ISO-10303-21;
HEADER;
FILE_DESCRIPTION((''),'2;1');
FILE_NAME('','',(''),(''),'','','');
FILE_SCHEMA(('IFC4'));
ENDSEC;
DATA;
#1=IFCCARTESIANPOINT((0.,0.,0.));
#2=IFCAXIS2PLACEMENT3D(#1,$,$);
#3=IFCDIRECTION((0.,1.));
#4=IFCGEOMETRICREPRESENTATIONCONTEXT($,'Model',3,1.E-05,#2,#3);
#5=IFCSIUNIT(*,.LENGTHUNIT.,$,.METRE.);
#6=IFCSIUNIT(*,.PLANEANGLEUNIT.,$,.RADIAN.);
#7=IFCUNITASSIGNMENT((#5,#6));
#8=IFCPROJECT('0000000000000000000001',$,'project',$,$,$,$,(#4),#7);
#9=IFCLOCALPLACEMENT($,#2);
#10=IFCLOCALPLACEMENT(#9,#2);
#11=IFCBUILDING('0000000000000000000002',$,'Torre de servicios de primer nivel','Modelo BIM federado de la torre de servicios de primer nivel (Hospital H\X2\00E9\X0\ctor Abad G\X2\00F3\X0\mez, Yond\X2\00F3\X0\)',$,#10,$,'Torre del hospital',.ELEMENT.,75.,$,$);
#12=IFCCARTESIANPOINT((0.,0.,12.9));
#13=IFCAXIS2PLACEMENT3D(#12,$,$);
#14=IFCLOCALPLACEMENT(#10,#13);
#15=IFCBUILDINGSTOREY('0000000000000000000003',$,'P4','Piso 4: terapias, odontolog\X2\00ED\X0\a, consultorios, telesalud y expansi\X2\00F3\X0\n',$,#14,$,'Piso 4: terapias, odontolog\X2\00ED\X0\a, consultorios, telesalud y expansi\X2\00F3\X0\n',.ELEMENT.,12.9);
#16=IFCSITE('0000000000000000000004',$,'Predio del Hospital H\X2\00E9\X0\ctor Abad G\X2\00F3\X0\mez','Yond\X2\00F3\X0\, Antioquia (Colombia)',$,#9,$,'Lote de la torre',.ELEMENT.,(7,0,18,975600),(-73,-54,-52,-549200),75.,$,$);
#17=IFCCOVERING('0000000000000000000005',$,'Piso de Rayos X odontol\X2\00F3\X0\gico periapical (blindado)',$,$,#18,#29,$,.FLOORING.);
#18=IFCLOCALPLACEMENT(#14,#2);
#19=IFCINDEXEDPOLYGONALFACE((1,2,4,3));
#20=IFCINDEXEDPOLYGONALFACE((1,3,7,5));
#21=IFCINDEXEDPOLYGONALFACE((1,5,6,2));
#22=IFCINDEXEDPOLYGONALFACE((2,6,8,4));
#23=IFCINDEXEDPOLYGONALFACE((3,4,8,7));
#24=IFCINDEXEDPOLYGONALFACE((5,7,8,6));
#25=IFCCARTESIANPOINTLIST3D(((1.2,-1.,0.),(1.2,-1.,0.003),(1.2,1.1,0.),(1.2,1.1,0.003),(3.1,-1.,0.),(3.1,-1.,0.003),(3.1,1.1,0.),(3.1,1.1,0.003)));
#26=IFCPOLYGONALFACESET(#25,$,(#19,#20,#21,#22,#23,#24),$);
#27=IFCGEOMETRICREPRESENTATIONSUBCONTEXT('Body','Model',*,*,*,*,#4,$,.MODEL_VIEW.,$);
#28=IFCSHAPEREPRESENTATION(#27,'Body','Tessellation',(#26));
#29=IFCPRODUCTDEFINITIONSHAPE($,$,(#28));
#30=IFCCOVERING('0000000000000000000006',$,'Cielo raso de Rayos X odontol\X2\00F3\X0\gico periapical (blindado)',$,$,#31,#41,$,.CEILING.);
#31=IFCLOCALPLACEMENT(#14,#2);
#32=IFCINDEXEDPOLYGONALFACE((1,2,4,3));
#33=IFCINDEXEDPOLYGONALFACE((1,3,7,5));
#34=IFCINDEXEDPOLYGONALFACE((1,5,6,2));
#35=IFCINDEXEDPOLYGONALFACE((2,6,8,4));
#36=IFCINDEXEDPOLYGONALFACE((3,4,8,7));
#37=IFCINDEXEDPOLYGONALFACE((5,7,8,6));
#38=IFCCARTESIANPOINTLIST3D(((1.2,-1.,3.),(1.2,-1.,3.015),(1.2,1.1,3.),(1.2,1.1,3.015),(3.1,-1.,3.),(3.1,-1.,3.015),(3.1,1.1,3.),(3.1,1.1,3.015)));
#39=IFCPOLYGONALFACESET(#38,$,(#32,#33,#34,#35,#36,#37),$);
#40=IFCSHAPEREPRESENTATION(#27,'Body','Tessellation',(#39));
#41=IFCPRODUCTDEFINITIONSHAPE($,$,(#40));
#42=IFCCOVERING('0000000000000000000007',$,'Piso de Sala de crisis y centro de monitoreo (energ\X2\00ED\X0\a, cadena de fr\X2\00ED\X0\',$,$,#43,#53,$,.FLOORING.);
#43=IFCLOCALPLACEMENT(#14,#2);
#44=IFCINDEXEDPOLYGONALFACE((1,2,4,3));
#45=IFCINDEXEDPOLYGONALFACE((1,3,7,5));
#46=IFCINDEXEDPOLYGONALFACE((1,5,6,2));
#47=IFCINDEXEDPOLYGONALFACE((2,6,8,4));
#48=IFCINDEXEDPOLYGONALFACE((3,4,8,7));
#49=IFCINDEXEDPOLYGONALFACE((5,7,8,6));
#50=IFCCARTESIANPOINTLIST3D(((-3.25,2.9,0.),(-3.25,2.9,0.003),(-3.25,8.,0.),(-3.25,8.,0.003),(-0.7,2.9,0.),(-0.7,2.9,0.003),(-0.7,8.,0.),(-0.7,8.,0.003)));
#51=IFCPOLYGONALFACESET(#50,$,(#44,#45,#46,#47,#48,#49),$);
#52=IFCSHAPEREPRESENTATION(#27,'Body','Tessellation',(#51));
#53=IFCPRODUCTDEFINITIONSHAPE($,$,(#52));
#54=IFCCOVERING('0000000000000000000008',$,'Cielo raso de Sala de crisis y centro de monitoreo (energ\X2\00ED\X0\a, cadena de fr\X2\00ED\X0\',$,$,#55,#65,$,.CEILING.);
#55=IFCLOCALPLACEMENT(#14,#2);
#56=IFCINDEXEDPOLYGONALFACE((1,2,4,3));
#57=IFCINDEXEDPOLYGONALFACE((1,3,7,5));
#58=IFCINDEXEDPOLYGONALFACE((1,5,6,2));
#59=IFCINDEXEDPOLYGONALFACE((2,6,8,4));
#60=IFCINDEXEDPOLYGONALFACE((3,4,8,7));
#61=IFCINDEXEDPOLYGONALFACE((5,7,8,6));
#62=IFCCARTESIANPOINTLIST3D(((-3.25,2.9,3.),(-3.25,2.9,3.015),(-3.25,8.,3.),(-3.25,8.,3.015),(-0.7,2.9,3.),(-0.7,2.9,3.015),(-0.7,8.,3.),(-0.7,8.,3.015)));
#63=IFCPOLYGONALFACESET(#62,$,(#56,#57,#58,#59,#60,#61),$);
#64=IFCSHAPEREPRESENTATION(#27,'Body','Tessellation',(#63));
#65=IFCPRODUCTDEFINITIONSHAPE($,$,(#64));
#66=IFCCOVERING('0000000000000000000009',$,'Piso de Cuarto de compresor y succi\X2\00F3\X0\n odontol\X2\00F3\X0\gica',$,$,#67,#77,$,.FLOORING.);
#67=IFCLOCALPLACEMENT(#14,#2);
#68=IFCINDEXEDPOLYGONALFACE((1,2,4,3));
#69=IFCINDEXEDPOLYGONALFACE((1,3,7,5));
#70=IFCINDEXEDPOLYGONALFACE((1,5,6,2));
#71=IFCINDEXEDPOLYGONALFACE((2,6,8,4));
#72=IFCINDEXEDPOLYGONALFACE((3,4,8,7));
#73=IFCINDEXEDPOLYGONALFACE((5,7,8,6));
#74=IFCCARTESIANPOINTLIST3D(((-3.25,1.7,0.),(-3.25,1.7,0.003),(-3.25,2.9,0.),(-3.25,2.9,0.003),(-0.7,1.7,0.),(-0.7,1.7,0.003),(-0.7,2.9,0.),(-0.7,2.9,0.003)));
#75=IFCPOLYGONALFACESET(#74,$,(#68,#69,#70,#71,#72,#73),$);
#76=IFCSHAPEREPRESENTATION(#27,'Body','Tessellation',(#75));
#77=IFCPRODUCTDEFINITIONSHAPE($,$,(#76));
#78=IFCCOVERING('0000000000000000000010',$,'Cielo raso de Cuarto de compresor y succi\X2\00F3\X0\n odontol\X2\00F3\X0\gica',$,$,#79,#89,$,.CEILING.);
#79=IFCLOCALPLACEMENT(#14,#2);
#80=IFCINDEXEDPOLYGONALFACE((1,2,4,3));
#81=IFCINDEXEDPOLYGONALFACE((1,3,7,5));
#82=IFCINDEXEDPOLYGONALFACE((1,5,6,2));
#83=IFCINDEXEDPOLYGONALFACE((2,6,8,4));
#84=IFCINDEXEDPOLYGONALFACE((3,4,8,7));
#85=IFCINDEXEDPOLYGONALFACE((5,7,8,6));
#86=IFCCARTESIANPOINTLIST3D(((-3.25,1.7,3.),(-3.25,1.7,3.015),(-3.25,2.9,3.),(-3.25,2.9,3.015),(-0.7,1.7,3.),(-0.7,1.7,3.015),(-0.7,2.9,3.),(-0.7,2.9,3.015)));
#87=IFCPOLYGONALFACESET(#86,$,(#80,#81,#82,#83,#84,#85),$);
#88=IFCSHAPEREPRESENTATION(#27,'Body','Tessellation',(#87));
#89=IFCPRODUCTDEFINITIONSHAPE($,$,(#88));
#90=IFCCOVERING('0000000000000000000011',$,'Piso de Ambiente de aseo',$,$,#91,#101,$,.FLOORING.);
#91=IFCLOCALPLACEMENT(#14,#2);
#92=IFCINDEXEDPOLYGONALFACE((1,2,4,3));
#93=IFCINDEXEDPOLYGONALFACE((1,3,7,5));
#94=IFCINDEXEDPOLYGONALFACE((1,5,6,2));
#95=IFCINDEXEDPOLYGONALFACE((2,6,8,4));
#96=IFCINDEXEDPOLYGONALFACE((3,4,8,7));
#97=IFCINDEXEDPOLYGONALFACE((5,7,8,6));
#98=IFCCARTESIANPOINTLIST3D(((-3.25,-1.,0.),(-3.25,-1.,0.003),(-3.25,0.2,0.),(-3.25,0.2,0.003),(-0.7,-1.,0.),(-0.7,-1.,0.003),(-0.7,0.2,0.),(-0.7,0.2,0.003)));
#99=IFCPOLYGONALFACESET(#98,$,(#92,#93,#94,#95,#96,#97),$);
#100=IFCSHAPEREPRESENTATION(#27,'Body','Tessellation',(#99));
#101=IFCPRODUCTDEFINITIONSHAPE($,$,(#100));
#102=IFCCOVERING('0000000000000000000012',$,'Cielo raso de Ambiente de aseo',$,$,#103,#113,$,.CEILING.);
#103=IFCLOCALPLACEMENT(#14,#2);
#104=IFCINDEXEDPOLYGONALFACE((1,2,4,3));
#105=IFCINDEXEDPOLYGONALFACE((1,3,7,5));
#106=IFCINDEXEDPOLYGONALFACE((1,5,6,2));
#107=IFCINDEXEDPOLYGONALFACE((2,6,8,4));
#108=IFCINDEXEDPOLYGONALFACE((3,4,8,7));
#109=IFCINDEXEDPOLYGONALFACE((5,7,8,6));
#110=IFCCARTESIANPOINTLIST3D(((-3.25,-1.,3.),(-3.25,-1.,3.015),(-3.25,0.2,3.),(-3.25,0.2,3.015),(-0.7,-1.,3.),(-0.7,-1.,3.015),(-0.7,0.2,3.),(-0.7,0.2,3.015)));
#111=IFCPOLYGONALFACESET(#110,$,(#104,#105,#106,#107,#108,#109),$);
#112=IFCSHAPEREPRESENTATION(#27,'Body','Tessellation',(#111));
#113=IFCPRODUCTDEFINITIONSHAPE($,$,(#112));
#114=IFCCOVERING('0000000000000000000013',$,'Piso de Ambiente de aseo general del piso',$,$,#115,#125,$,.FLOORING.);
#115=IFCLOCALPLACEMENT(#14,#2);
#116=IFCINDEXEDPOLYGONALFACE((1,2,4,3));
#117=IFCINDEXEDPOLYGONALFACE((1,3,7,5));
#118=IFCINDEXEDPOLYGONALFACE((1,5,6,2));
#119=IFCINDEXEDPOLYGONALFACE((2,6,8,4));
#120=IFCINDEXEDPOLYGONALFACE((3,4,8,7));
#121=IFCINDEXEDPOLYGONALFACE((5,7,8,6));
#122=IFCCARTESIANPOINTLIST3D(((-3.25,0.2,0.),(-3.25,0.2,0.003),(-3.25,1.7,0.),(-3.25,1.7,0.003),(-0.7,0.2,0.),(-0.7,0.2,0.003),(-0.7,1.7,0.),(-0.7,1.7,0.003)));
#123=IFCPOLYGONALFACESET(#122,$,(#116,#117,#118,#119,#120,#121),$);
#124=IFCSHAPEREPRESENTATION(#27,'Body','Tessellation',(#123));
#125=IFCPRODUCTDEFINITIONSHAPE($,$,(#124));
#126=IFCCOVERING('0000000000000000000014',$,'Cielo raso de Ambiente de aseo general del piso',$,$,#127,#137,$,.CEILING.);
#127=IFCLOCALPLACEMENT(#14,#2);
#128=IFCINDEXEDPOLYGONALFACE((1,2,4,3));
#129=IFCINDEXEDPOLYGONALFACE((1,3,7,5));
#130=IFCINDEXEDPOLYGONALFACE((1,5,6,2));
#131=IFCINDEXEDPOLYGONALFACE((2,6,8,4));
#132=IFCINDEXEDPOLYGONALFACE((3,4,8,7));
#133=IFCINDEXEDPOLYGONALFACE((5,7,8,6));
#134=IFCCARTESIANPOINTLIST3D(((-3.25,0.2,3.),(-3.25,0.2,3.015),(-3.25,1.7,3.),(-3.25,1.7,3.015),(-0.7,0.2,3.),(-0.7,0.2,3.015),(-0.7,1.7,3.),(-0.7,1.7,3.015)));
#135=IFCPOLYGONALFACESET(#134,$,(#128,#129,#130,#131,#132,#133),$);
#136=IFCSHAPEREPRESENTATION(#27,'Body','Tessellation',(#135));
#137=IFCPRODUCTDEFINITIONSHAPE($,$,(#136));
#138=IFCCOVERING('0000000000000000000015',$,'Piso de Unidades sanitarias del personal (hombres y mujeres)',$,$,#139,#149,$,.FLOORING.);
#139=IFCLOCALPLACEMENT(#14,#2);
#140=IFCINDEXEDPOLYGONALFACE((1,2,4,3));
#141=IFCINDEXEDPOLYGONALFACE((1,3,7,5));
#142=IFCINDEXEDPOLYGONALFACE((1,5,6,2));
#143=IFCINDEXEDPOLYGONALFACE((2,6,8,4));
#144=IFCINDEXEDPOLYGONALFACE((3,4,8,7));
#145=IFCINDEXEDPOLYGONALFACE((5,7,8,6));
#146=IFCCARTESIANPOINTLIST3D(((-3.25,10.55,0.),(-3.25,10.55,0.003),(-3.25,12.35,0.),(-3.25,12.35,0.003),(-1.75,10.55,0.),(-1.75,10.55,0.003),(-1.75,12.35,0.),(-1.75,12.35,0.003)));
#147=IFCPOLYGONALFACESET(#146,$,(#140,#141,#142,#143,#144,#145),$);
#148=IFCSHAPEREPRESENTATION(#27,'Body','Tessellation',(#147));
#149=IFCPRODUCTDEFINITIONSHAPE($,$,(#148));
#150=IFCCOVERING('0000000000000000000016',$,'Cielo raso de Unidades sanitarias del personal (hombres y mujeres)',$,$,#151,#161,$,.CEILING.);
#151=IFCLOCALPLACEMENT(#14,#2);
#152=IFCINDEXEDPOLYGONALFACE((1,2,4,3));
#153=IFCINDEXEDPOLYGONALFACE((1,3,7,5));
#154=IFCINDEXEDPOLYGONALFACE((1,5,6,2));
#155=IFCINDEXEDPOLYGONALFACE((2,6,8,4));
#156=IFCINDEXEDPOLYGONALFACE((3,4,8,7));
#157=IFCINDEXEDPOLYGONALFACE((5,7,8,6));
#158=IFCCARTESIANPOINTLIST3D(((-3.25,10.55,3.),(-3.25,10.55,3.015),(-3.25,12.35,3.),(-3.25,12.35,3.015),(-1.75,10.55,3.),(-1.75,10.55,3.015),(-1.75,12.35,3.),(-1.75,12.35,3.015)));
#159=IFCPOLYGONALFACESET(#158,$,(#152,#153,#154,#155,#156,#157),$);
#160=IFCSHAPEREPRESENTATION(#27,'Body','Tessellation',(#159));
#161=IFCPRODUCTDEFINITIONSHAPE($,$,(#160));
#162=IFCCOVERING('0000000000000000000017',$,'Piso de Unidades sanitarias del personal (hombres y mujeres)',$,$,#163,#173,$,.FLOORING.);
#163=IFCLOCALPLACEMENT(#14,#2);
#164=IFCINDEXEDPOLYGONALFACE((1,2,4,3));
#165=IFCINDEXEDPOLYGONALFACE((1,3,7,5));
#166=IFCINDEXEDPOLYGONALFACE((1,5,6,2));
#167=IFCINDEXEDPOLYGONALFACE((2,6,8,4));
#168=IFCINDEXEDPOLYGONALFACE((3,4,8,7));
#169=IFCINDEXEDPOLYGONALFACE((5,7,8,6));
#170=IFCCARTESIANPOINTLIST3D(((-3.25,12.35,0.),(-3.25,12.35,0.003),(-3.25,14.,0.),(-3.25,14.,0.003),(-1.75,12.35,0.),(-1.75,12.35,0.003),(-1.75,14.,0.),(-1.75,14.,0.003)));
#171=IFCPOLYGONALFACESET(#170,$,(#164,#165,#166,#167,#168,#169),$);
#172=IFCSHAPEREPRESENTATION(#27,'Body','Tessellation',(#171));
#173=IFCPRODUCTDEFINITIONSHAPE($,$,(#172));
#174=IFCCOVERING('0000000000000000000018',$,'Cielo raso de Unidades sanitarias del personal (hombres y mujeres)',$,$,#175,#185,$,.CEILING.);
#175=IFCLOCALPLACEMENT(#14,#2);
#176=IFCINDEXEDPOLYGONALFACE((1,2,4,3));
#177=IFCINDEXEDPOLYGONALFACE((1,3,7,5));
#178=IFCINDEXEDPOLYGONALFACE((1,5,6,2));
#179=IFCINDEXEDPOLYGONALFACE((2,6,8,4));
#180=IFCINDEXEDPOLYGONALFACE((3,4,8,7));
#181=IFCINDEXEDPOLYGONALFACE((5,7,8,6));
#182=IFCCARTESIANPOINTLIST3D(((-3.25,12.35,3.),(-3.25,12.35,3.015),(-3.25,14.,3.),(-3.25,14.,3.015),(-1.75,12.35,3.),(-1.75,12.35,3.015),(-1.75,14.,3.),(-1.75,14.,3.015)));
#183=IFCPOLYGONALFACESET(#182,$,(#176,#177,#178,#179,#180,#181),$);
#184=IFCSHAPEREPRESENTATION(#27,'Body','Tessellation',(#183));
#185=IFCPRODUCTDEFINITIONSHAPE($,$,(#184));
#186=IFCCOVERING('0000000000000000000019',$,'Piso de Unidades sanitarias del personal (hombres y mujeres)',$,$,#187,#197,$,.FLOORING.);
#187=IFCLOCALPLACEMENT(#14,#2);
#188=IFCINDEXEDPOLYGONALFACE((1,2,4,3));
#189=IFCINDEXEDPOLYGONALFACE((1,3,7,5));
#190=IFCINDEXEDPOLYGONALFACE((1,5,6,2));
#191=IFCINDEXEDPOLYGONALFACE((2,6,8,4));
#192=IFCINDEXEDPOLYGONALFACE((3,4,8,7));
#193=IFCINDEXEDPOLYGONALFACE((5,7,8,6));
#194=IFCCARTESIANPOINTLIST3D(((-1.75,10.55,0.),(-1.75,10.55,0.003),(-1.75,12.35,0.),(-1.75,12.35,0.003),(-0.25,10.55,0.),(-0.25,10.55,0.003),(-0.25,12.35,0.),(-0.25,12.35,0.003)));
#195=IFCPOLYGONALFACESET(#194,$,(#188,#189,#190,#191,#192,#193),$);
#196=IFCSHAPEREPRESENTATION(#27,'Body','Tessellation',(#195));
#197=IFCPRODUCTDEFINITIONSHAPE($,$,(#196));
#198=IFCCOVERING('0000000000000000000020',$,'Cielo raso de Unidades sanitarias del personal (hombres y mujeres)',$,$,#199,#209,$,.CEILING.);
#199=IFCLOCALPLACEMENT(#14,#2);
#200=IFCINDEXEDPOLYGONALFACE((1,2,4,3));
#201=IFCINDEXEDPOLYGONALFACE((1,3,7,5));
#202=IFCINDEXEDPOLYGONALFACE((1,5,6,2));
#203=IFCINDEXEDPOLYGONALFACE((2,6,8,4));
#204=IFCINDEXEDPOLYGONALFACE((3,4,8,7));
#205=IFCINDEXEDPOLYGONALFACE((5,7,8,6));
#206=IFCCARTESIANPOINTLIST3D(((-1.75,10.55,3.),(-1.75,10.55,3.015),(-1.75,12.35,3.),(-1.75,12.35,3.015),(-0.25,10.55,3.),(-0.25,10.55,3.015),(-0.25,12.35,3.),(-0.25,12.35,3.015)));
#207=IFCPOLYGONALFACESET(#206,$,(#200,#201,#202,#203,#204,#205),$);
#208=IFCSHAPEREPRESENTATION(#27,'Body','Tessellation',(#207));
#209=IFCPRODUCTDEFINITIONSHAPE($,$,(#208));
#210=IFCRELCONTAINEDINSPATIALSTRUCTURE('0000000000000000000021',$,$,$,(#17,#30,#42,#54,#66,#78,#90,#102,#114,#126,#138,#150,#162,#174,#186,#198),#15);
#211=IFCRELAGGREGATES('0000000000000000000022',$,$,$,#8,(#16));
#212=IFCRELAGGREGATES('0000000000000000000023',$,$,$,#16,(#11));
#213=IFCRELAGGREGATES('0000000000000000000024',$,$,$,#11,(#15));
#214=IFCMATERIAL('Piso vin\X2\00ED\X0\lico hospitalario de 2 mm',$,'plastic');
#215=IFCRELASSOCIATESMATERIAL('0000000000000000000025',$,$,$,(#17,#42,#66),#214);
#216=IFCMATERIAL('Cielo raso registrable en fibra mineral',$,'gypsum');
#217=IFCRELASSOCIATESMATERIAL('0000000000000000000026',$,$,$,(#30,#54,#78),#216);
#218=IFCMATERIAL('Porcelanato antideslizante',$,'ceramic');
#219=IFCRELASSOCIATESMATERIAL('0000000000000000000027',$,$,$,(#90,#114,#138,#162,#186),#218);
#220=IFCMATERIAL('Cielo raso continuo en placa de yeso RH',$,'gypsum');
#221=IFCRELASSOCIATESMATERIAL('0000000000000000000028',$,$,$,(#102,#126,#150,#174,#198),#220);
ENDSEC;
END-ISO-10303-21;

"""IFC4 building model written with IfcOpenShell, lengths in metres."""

from ifc_helpers import new_model, si_unit, direction, frame, origin, place, context, subcontext, project, spatial, indexed_curve, outline, extrude, material, element, save


model = new_model("IFC4")

# Units and contexts
model_context = context("Model", 3, precision=1e-05, world=origin(), true_north=direction((0.0, 1.0)))
body_context = subcontext(model_context, "Body", "Model", "MODEL_VIEW")
ifc_project = project(units=[si_unit("LENGTHUNIT", "METRE"), si_unit("PLANEANGLEUNIT", "RADIAN")], contexts=[model_context])

# Site, building, storey
site_placement = place(None, origin())
site = spatial("IfcSite", under=ifc_project, at=site_placement, Name="Predio del Hospital Héctor Abad Gómez", Description="Yondó, Antioquia (Colombia)", LongName="Lote de la torre", CompositionType="ELEMENT", RefLatitude=(7, 0, 18, 975600), RefLongitude=(-73, -54, -52, -549200), RefElevation=75.0)
building_placement = place(site_placement, origin())
building = spatial("IfcBuilding", under=site, at=building_placement, Name="Torre de servicios de primer nivel", Description="Modelo BIM federado de la torre de servicios de primer nivel (Hospital Héctor Abad Gómez, Yondó)", LongName="Torre del hospital", CompositionType="ELEMENT", ElevationOfRefHeight=75.0)
placement = place(building_placement, frame((0.0, 0.0, 12.9)))
storey = spatial("IfcBuildingStorey", under=building, at=placement, Name="P4", Description="Piso 4: terapias, odontología, consultorios, telesalud y expansión", LongName="Piso 4: terapias, odontología, consultorios, telesalud y expansión", CompositionType="ELEMENT", Elevation=12.9)

# Coverings
ifc_material_1 = material(Name="Porcelanato antideslizante", Category="ceramic")
ifc_material_2 = material(Name="Cielo raso continuo en placa de yeso RH", Category="gypsum")
ifc_material_3 = material(Name="Piso vinílico hospitalario de 2 mm", Category="plastic")
ifc_material_4 = material(Name="Cielo raso registrable en fibra mineral", Category="gypsum")
element("IfcCovering", 1, at=placement, inside=storey, material=ifc_material_3, Name="Piso de Rayos X odontológico periapical (blindado)", PredefinedType="FLOORING", context=body_context, shape_type="SweptSolid", body=[
    extrude(outline(indexed_curve([(1.2, -1.0), (3.1, -1.0), (3.1, 1.1), (1.2, 1.1), (1.2, -1.0)], self_intersect=False)), origin(), (0.0, 0.0, 1.0), 0.003),
])
element("IfcCovering", 2, at=placement, inside=storey, material=ifc_material_4, Name="Cielo raso de Rayos X odontológico periapical (blindado)", PredefinedType="CEILING", context=body_context, shape_type="SweptSolid", body=[
    extrude(outline(indexed_curve([(1.2, -1.0), (3.1, -1.0), (3.1, 1.1), (1.2, 1.1), (1.2, -1.0)], self_intersect=False)), frame((0.0, 0.0, 3.0)), (0.0, 0.0, 1.0), 0.015),
])
element("IfcCovering", 3, at=placement, inside=storey, material=ifc_material_3, Name="Piso de Sala de crisis y centro de monitoreo (energía, cadena de frí", PredefinedType="FLOORING", context=body_context, shape_type="SweptSolid", body=[
    extrude(outline(indexed_curve([(-3.25, 2.9), (-0.7, 2.9), (-0.7, 8.0), (-3.25, 8.0), (-3.25, 2.9)], self_intersect=False)), origin(), (0.0, 0.0, 1.0), 0.003),
])
element("IfcCovering", 4, at=placement, inside=storey, material=ifc_material_4, Name="Cielo raso de Sala de crisis y centro de monitoreo (energía, cadena de frí", PredefinedType="CEILING", context=body_context, shape_type="SweptSolid", body=[
    extrude(outline(indexed_curve([(-3.25, 2.9), (-0.7, 2.9), (-0.7, 8.0), (-3.25, 8.0), (-3.25, 2.9)], self_intersect=False)), frame((0.0, 0.0, 3.0)), (0.0, 0.0, 1.0), 0.015),
])
element("IfcCovering", 5, at=placement, inside=storey, material=ifc_material_3, Name="Piso de Cuarto de compresor y succión odontológica", PredefinedType="FLOORING", context=body_context, shape_type="SweptSolid", body=[
    extrude(outline(indexed_curve([(-3.25, 1.7), (-0.7, 1.7), (-0.7, 2.9), (-3.25, 2.9), (-3.25, 1.7)], self_intersect=False)), origin(), (0.0, 0.0, 1.0), 0.003),
])
element("IfcCovering", 6, at=placement, inside=storey, material=ifc_material_4, Name="Cielo raso de Cuarto de compresor y succión odontológica", PredefinedType="CEILING", context=body_context, shape_type="SweptSolid", body=[
    extrude(outline(indexed_curve([(-3.25, 1.7), (-0.7, 1.7), (-0.7, 2.9), (-3.25, 2.9), (-3.25, 1.7)], self_intersect=False)), frame((0.0, 0.0, 3.0)), (0.0, 0.0, 1.0), 0.015),
])
element("IfcCovering", 7, at=placement, inside=storey, material=ifc_material_1, Name="Piso de Ambiente de aseo", PredefinedType="FLOORING", context=body_context, shape_type="SweptSolid", body=[
    extrude(outline(indexed_curve([(-3.25, -1.0), (-0.7, -1.0), (-0.7, 0.2), (-3.25, 0.2), (-3.25, -1.0)], self_intersect=False)), origin(), (0.0, 0.0, 1.0), 0.003),
])
element("IfcCovering", 8, at=placement, inside=storey, material=ifc_material_2, Name="Cielo raso de Ambiente de aseo", PredefinedType="CEILING", context=body_context, shape_type="SweptSolid", body=[
    extrude(outline(indexed_curve([(-3.25, -1.0), (-0.7, -1.0), (-0.7, 0.2), (-3.25, 0.2), (-3.25, -1.0)], self_intersect=False)), frame((0.0, 0.0, 3.0)), (0.0, 0.0, 1.0), 0.015),
])
element("IfcCovering", 9, at=placement, inside=storey, material=ifc_material_1, Name="Piso de Ambiente de aseo general del piso", PredefinedType="FLOORING", context=body_context, shape_type="SweptSolid", body=[
    extrude(outline(indexed_curve([(-3.25, 0.2), (-0.7, 0.2), (-0.7, 1.7), (-3.25, 1.7), (-3.25, 0.2)], self_intersect=False)), origin(), (0.0, 0.0, 1.0), 0.003),
])
element("IfcCovering", 10, at=placement, inside=storey, material=ifc_material_2, Name="Cielo raso de Ambiente de aseo general del piso", PredefinedType="CEILING", context=body_context, shape_type="SweptSolid", body=[
    extrude(outline(indexed_curve([(-3.25, 0.2), (-0.7, 0.2), (-0.7, 1.7), (-3.25, 1.7), (-3.25, 0.2)], self_intersect=False)), frame((0.0, 0.0, 3.0)), (0.0, 0.0, 1.0), 0.015),
])
element("IfcCovering", 11, at=placement, inside=storey, material=ifc_material_1, Name="Piso de Unidades sanitarias del personal (hombres y mujeres)", PredefinedType="FLOORING", context=body_context, shape_type="SweptSolid", body=[
    extrude(outline(indexed_curve([(-3.25, 10.55), (-1.75, 10.55), (-1.75, 12.35), (-3.25, 12.35), (-3.25, 10.55)], self_intersect=False)), origin(), (0.0, 0.0, 1.0), 0.003),
])
element("IfcCovering", 12, at=placement, inside=storey, material=ifc_material_2, Name="Cielo raso de Unidades sanitarias del personal (hombres y mujeres)", PredefinedType="CEILING", context=body_context, shape_type="SweptSolid", body=[
    extrude(outline(indexed_curve([(-3.25, 10.55), (-1.75, 10.55), (-1.75, 12.35), (-3.25, 12.35), (-3.25, 10.55)], self_intersect=False)), frame((0.0, 0.0, 3.0)), (0.0, 0.0, 1.0), 0.015),
])
element("IfcCovering", 13, at=placement, inside=storey, material=ifc_material_1, Name="Piso de Unidades sanitarias del personal (hombres y mujeres)", PredefinedType="FLOORING", context=body_context, shape_type="SweptSolid", body=[
    extrude(outline(indexed_curve([(-3.25, 12.35), (-1.75, 12.35), (-1.75, 14.0), (-3.25, 14.0), (-3.25, 12.35)], self_intersect=False)), origin(), (0.0, 0.0, 1.0), 0.003),
])
element("IfcCovering", 14, at=placement, inside=storey, material=ifc_material_2, Name="Cielo raso de Unidades sanitarias del personal (hombres y mujeres)", PredefinedType="CEILING", context=body_context, shape_type="SweptSolid", body=[
    extrude(outline(indexed_curve([(-3.25, 12.35), (-1.75, 12.35), (-1.75, 14.0), (-3.25, 14.0), (-3.25, 12.35)], self_intersect=False)), frame((0.0, 0.0, 3.0)), (0.0, 0.0, 1.0), 0.015),
])
element("IfcCovering", 15, at=placement, inside=storey, material=ifc_material_1, Name="Piso de Unidades sanitarias del personal (hombres y mujeres)", PredefinedType="FLOORING", context=body_context, shape_type="SweptSolid", body=[
    extrude(outline(indexed_curve([(-1.75, 10.55), (-0.25, 10.55), (-0.25, 12.35), (-1.75, 12.35), (-1.75, 10.55)], self_intersect=False)), origin(), (0.0, 0.0, 1.0), 0.003),
])
element("IfcCovering", 16, at=placement, inside=storey, material=ifc_material_2, Name="Cielo raso de Unidades sanitarias del personal (hombres y mujeres)", PredefinedType="CEILING", context=body_context, shape_type="SweptSolid", body=[
    extrude(outline(indexed_curve([(-1.75, 10.55), (-0.25, 10.55), (-0.25, 12.35), (-1.75, 12.35), (-1.75, 10.55)], self_intersect=False)), frame((0.0, 0.0, 3.0)), (0.0, 0.0, 1.0), 0.015),
])

save(model, "model.ifc")
